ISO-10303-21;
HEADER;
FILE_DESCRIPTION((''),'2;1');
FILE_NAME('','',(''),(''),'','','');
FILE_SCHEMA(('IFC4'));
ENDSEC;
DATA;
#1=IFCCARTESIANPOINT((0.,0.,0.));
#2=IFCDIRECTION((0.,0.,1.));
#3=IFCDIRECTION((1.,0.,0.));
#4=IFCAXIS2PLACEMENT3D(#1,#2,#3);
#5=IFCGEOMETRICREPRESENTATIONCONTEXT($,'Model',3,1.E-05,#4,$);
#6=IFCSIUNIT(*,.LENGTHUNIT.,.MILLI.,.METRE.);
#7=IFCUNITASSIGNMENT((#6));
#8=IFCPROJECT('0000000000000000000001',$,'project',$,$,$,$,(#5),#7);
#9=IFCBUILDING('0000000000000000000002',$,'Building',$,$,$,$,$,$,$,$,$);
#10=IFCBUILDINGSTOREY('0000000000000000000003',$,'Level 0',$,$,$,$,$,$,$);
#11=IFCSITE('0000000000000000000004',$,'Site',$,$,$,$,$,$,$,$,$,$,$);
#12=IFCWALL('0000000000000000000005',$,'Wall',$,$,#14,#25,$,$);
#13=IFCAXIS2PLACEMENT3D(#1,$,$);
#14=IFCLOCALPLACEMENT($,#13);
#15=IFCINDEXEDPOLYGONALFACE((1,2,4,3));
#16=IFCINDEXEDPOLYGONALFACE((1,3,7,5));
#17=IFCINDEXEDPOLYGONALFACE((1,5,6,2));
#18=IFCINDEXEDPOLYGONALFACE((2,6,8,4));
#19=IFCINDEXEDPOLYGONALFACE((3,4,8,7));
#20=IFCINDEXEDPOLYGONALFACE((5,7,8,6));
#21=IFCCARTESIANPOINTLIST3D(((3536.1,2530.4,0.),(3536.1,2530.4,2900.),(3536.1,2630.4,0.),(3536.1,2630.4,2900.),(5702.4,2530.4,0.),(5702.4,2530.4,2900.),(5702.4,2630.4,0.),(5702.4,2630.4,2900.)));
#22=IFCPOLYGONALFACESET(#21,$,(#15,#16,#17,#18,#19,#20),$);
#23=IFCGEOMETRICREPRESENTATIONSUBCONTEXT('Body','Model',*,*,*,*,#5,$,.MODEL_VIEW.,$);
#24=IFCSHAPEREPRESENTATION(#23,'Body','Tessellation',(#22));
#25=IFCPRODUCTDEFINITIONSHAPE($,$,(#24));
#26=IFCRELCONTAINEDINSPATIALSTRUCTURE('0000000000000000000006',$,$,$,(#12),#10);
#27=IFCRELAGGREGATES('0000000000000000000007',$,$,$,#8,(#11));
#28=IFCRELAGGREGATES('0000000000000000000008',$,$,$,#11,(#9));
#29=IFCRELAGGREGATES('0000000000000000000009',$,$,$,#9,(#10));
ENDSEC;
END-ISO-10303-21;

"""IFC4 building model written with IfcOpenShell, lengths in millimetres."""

from ifc_helpers import new_model, si_unit, frame, origin_with_axes, place, context, subcontext, project, spatial, indexed_curve, outline, extrude, element, save


model = new_model("IFC4")

# Units and contexts
model_context = context("Model", 3, precision=1e-05, world=origin_with_axes())
body_context = subcontext(model_context, "Body", "Model", "MODEL_VIEW")
ifc_project = project(units=[si_unit("LENGTHUNIT", "METRE", prefix="MILLI")], contexts=[model_context])

# Site, building, storey
site = spatial("IfcSite", under=ifc_project, Name="Site")
building = spatial("IfcBuilding", under=site, Name="Building")
storey = spatial("IfcBuildingStorey", under=building, Name="Level 0")

# Wall
wall_1_placement = place(None, frame((3536.1, 2530.4, 0.0), z_axis=(0.0, 0.0, 1.0), x_axis=(1.0, 0.0, 0.0)))
element("IfcWall", 1, at=wall_1_placement, inside=storey, Name="Wall", context=body_context, shape_type="SweptSolid", body=[
    extrude(outline(indexed_curve([(0.0, 0.0), (0.0, 99.9), (2166.3, 99.9), (2166.3, 0.0), (0.0, 0.0)], self_intersect=False)), origin_with_axes(), (0.0, 0.0, 1.0), 2900.0),
])

save(model, "model.ifc")
